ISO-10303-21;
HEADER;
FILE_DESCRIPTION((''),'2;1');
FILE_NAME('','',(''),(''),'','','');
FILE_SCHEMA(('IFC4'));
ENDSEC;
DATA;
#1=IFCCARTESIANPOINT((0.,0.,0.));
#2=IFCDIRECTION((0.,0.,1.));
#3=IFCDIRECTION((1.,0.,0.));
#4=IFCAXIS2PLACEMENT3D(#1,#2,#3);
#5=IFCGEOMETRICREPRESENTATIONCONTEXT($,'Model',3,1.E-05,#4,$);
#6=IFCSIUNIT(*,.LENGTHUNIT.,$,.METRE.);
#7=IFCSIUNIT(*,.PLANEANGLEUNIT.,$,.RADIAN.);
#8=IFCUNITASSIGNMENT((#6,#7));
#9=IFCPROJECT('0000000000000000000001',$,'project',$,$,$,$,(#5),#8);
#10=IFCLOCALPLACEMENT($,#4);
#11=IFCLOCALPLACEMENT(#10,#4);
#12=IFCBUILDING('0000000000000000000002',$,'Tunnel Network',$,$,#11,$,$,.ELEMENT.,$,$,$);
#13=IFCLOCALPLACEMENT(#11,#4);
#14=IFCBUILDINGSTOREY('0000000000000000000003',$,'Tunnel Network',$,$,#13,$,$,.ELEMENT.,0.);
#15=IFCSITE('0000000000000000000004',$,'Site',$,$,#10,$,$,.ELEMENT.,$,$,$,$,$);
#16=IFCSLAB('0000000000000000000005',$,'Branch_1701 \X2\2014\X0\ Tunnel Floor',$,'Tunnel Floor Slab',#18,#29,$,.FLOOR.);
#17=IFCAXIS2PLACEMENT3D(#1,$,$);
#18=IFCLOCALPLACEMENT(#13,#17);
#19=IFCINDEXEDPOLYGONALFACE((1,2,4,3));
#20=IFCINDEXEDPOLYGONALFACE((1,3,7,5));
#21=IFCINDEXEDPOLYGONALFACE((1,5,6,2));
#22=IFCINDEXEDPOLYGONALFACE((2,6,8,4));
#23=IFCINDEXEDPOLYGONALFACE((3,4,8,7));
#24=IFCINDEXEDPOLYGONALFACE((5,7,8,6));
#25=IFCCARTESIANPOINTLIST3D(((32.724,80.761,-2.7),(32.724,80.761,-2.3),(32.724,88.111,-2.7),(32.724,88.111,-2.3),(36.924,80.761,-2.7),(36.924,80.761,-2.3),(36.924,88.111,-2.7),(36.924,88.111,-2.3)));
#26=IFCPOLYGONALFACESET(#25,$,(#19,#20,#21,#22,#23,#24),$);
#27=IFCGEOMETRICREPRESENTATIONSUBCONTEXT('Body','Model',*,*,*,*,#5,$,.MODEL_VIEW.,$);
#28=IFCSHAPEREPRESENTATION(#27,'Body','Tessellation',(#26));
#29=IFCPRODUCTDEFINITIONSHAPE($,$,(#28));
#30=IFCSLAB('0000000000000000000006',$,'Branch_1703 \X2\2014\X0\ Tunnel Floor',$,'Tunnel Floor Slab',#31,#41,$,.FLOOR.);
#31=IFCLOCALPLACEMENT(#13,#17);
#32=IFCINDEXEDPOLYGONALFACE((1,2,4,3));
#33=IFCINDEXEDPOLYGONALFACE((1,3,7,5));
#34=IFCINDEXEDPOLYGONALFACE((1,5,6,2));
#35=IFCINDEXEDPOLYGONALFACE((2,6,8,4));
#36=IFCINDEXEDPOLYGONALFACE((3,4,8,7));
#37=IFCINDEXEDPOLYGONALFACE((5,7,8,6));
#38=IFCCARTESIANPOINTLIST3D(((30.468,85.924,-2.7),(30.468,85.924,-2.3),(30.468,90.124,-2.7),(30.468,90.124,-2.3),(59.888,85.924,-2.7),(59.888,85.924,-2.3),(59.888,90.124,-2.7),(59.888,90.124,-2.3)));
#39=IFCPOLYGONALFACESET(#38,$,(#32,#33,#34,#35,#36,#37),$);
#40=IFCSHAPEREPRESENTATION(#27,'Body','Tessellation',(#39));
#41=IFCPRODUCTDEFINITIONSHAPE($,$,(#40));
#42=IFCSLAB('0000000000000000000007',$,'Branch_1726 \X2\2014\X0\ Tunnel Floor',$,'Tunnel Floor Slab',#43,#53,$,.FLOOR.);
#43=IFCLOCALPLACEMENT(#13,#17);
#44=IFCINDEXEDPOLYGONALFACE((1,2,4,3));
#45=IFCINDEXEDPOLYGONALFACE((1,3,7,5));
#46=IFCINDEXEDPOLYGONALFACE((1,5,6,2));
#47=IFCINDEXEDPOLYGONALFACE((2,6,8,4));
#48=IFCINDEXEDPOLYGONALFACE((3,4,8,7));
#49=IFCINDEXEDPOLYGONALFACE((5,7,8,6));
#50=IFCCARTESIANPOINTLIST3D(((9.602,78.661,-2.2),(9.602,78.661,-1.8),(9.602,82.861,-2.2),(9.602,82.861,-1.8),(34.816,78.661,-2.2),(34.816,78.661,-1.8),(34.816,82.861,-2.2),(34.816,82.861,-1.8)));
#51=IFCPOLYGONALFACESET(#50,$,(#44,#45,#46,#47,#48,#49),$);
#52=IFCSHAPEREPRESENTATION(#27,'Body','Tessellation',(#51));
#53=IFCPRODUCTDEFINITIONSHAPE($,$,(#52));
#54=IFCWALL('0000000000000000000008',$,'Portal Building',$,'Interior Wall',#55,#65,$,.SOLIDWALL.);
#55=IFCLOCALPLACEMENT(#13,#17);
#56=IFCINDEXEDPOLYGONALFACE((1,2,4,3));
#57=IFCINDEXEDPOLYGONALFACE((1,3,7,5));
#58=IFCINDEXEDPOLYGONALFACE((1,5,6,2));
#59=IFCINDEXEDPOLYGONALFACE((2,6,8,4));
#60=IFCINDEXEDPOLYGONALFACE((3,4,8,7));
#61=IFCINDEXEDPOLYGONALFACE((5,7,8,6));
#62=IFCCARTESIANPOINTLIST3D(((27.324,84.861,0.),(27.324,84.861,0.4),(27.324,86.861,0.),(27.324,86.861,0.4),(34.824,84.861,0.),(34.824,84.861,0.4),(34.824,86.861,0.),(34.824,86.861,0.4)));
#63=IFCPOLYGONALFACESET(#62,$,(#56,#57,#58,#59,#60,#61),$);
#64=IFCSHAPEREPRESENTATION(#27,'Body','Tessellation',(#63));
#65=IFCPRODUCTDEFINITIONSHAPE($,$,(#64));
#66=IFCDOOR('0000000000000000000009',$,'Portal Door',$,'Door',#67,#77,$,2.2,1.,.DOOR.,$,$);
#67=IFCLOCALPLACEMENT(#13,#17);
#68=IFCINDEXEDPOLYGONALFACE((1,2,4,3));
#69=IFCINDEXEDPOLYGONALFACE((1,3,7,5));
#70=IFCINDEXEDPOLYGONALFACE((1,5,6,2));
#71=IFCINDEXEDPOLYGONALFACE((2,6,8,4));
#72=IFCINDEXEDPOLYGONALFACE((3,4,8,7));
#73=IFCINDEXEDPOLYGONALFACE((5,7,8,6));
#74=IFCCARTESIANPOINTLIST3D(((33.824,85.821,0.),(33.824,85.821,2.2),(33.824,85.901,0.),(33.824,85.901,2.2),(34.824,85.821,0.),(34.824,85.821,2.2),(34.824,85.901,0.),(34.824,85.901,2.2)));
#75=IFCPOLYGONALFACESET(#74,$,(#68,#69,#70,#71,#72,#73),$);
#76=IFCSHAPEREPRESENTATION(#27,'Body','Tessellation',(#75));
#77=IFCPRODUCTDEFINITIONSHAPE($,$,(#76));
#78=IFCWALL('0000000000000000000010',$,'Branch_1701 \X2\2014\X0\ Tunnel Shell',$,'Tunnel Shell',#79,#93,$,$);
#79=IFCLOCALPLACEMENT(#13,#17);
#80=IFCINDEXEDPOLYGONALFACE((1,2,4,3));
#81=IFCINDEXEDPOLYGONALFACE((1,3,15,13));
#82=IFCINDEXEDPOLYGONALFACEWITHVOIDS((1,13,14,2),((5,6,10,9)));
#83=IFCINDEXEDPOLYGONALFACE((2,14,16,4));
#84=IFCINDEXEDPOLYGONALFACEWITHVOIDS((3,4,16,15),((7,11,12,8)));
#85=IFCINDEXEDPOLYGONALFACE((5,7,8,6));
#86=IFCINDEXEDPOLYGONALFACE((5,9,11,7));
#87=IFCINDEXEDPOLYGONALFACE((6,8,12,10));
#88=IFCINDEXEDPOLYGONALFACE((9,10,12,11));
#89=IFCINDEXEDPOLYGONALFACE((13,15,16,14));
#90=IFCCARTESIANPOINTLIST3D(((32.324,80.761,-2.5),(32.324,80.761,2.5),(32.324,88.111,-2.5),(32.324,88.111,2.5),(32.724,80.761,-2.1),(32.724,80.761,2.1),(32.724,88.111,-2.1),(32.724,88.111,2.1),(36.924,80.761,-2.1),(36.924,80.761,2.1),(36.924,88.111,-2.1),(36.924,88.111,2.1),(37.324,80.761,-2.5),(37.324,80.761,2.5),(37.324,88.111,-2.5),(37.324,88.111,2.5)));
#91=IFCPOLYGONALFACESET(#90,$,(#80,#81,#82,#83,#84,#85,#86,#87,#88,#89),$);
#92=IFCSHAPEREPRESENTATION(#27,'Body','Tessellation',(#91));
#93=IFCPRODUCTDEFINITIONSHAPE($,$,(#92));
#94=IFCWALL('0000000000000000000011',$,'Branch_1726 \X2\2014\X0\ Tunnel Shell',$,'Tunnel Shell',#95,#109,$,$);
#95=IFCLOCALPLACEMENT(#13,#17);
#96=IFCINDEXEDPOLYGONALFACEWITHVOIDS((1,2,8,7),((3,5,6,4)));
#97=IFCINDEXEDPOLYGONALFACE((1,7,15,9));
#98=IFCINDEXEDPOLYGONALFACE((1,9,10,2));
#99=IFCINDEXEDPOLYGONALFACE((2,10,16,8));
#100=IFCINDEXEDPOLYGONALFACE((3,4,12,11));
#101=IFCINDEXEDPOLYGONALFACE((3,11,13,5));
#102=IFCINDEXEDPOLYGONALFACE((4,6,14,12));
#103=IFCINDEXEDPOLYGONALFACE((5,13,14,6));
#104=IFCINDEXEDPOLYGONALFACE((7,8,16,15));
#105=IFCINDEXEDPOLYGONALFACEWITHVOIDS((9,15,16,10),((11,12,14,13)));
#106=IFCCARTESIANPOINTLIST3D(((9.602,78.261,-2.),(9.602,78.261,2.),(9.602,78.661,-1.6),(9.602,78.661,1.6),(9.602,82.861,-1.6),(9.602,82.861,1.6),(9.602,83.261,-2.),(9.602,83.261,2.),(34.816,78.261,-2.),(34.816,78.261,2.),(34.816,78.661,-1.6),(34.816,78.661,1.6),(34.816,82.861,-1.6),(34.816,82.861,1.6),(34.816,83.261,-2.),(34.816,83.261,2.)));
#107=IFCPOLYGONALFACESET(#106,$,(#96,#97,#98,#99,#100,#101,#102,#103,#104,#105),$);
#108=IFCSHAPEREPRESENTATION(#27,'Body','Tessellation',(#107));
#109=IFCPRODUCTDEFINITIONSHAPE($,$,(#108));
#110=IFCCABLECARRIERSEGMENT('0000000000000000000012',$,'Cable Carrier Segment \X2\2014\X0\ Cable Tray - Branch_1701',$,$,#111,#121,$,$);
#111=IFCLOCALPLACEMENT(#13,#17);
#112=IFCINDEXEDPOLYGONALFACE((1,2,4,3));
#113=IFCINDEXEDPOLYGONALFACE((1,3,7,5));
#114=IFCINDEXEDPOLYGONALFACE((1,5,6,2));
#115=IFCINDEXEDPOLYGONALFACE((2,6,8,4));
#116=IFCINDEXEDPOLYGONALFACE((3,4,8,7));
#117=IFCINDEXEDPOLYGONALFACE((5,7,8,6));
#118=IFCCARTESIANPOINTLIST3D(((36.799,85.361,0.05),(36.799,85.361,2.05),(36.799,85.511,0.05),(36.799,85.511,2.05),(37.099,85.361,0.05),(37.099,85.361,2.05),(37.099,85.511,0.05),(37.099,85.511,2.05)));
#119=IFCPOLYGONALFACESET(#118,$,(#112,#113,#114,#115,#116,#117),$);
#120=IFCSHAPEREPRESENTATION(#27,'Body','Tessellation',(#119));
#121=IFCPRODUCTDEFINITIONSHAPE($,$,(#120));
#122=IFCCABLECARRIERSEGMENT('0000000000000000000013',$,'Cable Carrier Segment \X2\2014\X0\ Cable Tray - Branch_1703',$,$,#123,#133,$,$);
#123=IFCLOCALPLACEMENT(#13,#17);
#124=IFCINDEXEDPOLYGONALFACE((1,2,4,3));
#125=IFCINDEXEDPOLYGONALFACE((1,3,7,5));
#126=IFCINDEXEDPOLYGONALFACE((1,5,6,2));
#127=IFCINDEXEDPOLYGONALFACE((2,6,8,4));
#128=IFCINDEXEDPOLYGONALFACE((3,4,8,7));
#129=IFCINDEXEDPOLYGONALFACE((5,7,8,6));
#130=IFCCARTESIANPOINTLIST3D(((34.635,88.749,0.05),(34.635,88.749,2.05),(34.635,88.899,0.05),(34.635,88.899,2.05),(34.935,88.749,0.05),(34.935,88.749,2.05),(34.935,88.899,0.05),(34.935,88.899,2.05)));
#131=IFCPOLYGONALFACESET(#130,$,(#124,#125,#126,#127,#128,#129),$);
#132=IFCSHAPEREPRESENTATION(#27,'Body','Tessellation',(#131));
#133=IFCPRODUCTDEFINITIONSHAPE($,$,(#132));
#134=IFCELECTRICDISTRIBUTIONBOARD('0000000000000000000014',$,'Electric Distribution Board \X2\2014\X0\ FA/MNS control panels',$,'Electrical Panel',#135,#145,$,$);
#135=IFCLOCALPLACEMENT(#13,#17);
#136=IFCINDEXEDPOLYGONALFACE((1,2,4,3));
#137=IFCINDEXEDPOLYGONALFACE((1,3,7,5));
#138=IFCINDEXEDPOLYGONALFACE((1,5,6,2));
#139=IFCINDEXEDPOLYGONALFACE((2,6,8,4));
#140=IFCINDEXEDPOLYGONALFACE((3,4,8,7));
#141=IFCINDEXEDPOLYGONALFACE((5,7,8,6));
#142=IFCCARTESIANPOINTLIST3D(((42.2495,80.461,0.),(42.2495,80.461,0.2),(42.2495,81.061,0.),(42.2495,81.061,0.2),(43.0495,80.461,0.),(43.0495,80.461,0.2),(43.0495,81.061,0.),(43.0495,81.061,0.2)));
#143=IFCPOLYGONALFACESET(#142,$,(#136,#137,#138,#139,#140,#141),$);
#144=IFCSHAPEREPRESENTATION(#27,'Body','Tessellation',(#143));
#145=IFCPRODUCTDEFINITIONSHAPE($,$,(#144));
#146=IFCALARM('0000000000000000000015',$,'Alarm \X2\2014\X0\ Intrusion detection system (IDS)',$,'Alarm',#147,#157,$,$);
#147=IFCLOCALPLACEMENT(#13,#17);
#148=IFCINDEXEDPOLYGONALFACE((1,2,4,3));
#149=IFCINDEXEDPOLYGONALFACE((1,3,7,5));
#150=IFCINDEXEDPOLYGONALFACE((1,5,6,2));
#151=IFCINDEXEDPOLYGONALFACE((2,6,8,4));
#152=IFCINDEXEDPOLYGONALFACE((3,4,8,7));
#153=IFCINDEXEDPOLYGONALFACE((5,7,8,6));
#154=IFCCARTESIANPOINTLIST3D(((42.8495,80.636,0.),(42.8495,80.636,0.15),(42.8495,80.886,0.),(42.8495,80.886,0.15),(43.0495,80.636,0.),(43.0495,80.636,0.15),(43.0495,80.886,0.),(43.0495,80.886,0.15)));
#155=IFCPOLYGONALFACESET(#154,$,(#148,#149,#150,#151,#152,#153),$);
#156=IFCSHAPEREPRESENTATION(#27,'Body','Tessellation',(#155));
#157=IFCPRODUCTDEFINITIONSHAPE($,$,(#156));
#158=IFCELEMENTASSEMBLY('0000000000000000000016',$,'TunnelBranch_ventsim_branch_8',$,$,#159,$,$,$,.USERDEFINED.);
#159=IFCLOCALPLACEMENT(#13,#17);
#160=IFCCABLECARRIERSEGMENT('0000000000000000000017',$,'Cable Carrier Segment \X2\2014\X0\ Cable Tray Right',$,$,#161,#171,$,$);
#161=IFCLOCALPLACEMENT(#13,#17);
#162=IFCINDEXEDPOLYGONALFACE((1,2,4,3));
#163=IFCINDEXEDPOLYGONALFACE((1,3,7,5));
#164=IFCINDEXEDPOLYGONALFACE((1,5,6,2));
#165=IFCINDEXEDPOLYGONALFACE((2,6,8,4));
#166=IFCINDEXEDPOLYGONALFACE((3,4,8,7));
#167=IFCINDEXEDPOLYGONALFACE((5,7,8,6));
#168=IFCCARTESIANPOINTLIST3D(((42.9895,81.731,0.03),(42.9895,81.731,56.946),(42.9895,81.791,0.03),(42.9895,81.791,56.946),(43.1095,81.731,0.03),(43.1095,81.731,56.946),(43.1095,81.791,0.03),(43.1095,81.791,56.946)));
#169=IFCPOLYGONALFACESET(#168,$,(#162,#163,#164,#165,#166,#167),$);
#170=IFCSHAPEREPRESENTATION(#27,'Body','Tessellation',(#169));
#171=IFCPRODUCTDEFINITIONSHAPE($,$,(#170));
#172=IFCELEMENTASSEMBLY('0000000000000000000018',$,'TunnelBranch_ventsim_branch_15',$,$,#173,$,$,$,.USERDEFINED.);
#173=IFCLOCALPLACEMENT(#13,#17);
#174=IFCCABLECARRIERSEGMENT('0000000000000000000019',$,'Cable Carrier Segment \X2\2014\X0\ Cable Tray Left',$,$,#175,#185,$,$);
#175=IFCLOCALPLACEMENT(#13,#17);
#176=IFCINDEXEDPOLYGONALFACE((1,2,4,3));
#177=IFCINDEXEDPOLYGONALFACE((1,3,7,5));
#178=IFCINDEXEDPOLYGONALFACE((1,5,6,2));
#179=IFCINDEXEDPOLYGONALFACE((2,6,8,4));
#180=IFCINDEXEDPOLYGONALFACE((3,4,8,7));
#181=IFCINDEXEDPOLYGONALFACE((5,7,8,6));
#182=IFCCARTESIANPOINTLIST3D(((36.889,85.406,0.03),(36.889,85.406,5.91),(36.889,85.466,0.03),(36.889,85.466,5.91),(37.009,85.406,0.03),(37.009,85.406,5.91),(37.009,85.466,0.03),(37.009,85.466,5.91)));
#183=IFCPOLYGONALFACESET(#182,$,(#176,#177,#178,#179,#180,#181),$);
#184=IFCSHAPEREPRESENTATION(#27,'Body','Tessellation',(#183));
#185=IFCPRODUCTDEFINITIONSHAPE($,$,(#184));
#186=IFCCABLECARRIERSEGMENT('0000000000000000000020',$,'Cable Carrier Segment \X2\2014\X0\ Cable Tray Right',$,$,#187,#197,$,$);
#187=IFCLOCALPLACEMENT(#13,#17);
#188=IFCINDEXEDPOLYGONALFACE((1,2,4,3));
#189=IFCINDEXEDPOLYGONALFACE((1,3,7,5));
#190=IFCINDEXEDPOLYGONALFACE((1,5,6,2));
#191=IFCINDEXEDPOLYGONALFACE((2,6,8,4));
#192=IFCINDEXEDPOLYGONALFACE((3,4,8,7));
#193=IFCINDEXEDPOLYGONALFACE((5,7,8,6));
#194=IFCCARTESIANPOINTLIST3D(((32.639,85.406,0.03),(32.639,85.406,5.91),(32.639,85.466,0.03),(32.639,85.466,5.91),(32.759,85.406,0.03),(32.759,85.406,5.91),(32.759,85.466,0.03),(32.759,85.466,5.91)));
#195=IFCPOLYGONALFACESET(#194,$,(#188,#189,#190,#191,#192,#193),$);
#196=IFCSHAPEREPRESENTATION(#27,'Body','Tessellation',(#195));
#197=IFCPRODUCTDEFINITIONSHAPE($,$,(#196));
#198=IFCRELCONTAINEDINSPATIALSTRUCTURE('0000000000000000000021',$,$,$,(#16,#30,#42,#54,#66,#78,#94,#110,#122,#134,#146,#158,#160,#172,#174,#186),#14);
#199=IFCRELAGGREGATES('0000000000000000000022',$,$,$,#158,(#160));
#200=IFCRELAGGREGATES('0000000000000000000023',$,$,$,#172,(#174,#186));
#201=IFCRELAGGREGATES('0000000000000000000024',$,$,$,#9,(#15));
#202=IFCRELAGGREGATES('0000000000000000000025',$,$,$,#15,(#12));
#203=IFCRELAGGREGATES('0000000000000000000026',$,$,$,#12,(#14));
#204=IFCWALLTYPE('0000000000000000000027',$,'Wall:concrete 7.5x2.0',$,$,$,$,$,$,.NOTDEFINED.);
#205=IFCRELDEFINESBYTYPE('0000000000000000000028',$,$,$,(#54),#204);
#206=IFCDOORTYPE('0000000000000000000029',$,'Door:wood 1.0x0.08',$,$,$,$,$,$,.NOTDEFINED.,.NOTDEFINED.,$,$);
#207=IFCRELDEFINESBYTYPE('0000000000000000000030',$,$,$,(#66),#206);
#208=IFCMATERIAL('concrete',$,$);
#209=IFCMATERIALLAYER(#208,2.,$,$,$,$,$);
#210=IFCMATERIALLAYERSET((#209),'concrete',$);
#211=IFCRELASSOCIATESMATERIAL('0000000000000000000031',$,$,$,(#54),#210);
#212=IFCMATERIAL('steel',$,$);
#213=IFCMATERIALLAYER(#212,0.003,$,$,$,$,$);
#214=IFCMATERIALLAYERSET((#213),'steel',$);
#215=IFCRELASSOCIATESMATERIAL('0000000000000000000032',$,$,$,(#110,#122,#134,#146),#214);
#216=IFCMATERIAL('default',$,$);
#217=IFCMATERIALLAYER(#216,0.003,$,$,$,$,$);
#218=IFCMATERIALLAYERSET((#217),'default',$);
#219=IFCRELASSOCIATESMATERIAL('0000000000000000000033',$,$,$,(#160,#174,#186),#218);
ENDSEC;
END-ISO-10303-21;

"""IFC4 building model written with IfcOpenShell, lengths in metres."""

from ifc_helpers import new_model, si_unit, frame, origin_with_axes, origin_2d_with_axis, place, context, subcontext, project, spatial, rectangle, hollow_rectangle, extrude, material, layer, layer_set, layer_usage, type_object, element, aggregate, save


model = new_model("IFC4")

# Units and contexts
model_context = context("Model", 3, precision=1e-05, world=origin_with_axes())
body_context = subcontext(model_context, "Body", "Model", "MODEL_VIEW")
ifc_project = project(units=[si_unit("LENGTHUNIT", "METRE"), si_unit("PLANEANGLEUNIT", "RADIAN")], contexts=[model_context])

# Site, building, storey
site_placement = place(None, origin_with_axes())
site = spatial("IfcSite", under=ifc_project, at=site_placement, Name="Site", CompositionType="ELEMENT")
building_placement = place(site_placement, origin_with_axes())
building = spatial("IfcBuilding", under=site, at=building_placement, Name="Tunnel Network", CompositionType="ELEMENT")
storey_placement = place(building_placement, origin_with_axes())
storey = spatial("IfcBuildingStorey", under=building, at=storey_placement, Name="Tunnel Network", CompositionType="ELEMENT", Elevation=0.0)

# Slabs
placement_1 = place(storey_placement, frame((34.824, 80.761, 0.0), z_axis=(0.0, 0.0, 1.0), x_axis=(0.0, 1.0, 0.0)))
element("IfcSlab", 1, at=placement_1, inside=storey, Name="Branch_1701 — Tunnel Floor", ObjectType="Tunnel Floor Slab", PredefinedType="FLOOR", context=body_context, shape_type="SweptSolid", body=[
    extrude(rectangle(XDim=0.4, YDim=4.2, at=origin_2d_with_axis()), frame((0.0, 0.0, -2.5), z_axis=(1.0, 0.0, 0.0), x_axis=(0.0, 0.0, 1.0)), (0.0, 0.0, 1.0), 7.35),
])
slab_1_placement = place(storey_placement, frame((30.468, 88.024, 0.0), z_axis=(0.0, 0.0, 1.0), x_axis=(1.0, 0.0, 0.0)))
element("IfcSlab", 2, at=slab_1_placement, inside=storey, Name="Branch_1703 — Tunnel Floor", ObjectType="Tunnel Floor Slab", PredefinedType="FLOOR", context=body_context, shape_type="SweptSolid", body=[
    extrude(rectangle(XDim=0.4, YDim=4.2, at=origin_2d_with_axis()), frame((0.0, 0.0, -2.5), z_axis=(1.0, 0.0, 0.0), x_axis=(0.0, 0.0, 1.0)), (0.0, 0.0, 1.0), 29.42),
])
placement_2 = place(storey_placement, frame((34.816, 80.761, 0.0), z_axis=(0.0, 0.0, 1.0), x_axis=(-1.0, 0.0, 0.0)))
element("IfcSlab", 3, at=placement_2, inside=storey, Name="Branch_1726 — Tunnel Floor", ObjectType="Tunnel Floor Slab", PredefinedType="FLOOR", context=body_context, shape_type="SweptSolid", body=[
    extrude(rectangle(XDim=0.4, YDim=4.2, at=origin_2d_with_axis()), frame((0.0, 0.0, -2.0), z_axis=(1.0, 0.0, 0.0), x_axis=(0.0, 0.0, 1.0)), (0.0, 0.0, 1.0), 25.214),
])

# Wall
ifc_material_1 = material(Name="concrete")
ifc_layer_1 = layer(ifc_material_1, 2.0)
ifc_layer_set_1 = layer_set([ifc_layer_1], Name="concrete")
ifc_layer_usage_1 = layer_usage(ifc_layer_set_1, "AXIS2", "POSITIVE", 0.0)
wall_type = type_object("IfcWallType", Name="Wall:concrete 7.5x2.0")
wall_1_placement = place(storey_placement, frame((31.074, 85.861, 0.0), z_axis=(0.0, 0.0, 1.0), x_axis=(1.0, 0.0, 0.0)))
element("IfcWall", 4, at=wall_1_placement, inside=storey, type_object=wall_type, material=ifc_layer_usage_1, Name="Portal Building", ObjectType="Interior Wall", PredefinedType="SOLIDWALL", context=body_context, shape_type="SweptSolid", body=[
    extrude(rectangle(XDim=7.5, YDim=2.0, at=origin_2d_with_axis()), origin_with_axes(), (0.0, 0.0, 1.0), 0.4),
])

# Door
door_type = type_object("IfcDoorType", Name="Door:wood 1.0x0.08")
door_placement = place(storey_placement, frame((34.324, 85.861, 0.0), z_axis=(0.0, 0.0, 1.0), x_axis=(1.0, 0.0, 0.0)))
element("IfcDoor", 5, at=door_placement, inside=storey, type_object=door_type, Name="Portal Door", ObjectType="Door", OverallHeight=2.2, OverallWidth=1.0, PredefinedType="DOOR", context=body_context, shape_type="SweptSolid", body=[
    extrude(rectangle(XDim=1.0, YDim=0.08, at=origin_2d_with_axis()), origin_with_axes(), (0.0, 0.0, 1.0), 2.2),
])

# Walls
element("IfcWall", 6, at=placement_1, inside=storey, Name="Branch_1701 — Tunnel Shell", ObjectType="Tunnel Shell", context=body_context, shape_type="SweptSolid", body=[
    extrude(hollow_rectangle(XDim=5.0, YDim=5.0, WallThickness=0.4, at=origin_2d_with_axis()), frame((0.0, 0.0, 0.0), z_axis=(1.0, 0.0, 0.0), x_axis=(0.0, 0.0, 1.0)), (0.0, 0.0, 1.0), 7.35),
])
element("IfcWall", 7, at=placement_2, inside=storey, Name="Branch_1726 — Tunnel Shell", ObjectType="Tunnel Shell", context=body_context, shape_type="SweptSolid", body=[
    extrude(hollow_rectangle(XDim=4.0, YDim=5.0, WallThickness=0.4, at=origin_2d_with_axis()), frame((0.0, 0.0, 0.0), z_axis=(1.0, 0.0, 0.0), x_axis=(0.0, 0.0, 1.0)), (0.0, 0.0, 1.0), 25.214),
])

# Cable carrier segments
ifc_material_2 = material(Name="steel")
ifc_layer_2 = layer(ifc_material_2, 0.003)
ifc_layer_set_2 = layer_set([ifc_layer_2], Name="steel")
ifc_layer_usage_2 = layer_usage(ifc_layer_set_2, "AXIS2", "POSITIVE", 0.0)
cable_carrier_segment_1_placement = place(storey_placement, frame((36.949, 85.436, 0.05), z_axis=(0.0, 0.0, 1.0), x_axis=(-1.0, 0.0, 0.0)))
element("IfcCableCarrierSegment", 8, at=cable_carrier_segment_1_placement, inside=storey, material=ifc_layer_usage_2, Name="Cable Carrier Segment — Cable Tray - Branch_1701", context=body_context, shape_type="SweptSolid", body=[
    extrude(rectangle(XDim=0.3, YDim=0.15, at=origin_2d_with_axis()), origin_with_axes(), (0.0, 0.0, 1.0), 2.0),
])
ifc_layer_usage_3 = layer_usage(ifc_layer_set_2, "AXIS2", "POSITIVE", 0.0)
cable_carrier_segment_2_placement = place(storey_placement, frame((34.785, 88.824, 0.05), z_axis=(0.0, 0.0, 1.0), x_axis=(-1.0, 0.0, 0.0)))
element("IfcCableCarrierSegment", 9, at=cable_carrier_segment_2_placement, inside=storey, material=ifc_layer_usage_3, Name="Cable Carrier Segment — Cable Tray - Branch_1703", context=body_context, shape_type="SweptSolid", body=[
    extrude(rectangle(XDim=0.3, YDim=0.15, at=origin_2d_with_axis()), origin_with_axes(), (0.0, 0.0, 1.0), 2.0),
])

# Electric distribution board
ifc_layer_usage_4 = layer_usage(ifc_layer_set_2, "AXIS2", "POSITIVE", 0.0)
electric_distribution_board_placement = place(storey_placement, frame((43.0495, 80.761, 0.1), z_axis=(-1.0, 0.0, 0.0), x_axis=(0.0, 1.0, 0.0)))
element("IfcElectricDistributionBoard", 10, at=electric_distribution_board_placement, inside=storey, material=ifc_layer_usage_4, Name="Electric Distribution Board — FA/MNS control panels", ObjectType="Electrical Panel", context=body_context, shape_type="SweptSolid", body=[
    extrude(rectangle(XDim=0.6, YDim=0.2, at=origin_2d_with_axis()), origin_with_axes(), (0.0, 0.0, 1.0), 0.8),
])

# Alarm
ifc_layer_usage_5 = layer_usage(ifc_layer_set_2, "AXIS2", "POSITIVE", 0.0)
alarm_1_placement = place(storey_placement, frame((43.0495, 80.761, 0.075), z_axis=(-1.0, 0.0, 0.0), x_axis=(0.0, 1.0, 0.0)))
element("IfcAlarm", 11, at=alarm_1_placement, inside=storey, material=ifc_layer_usage_5, Name="Alarm — Intrusion detection system (IDS)", ObjectType="Alarm", context=body_context, shape_type="SweptSolid", body=[
    extrude(rectangle(XDim=0.25, YDim=0.15, at=origin_2d_with_axis()), origin_with_axes(), (0.0, 0.0, 1.0), 0.2),
])

# Element assembly, cable carrier segment
assembly_1_placement = place(storey_placement, frame((47.6745, 80.761, 43.5572), z_axis=(0.0, 1.0, 0.0), x_axis=(-1.0, 0.0, 0.0)))
assembly_1 = element("IfcElementAssembly", 12, at=assembly_1_placement, inside=storey, Name="TunnelBranch_ventsim_branch_8", PredefinedType="USERDEFINED")
ifc_material_3 = material(Name="default")
ifc_layer_3 = layer(ifc_material_3, 0.003)
ifc_layer_set_3 = layer_set([ifc_layer_3], Name="default")
ifc_layer_usage_6 = layer_usage(ifc_layer_set_3, "AXIS2", "POSITIVE", 0.0)
cable_carrier_segment_3_placement = place(storey_placement, frame((43.0495, 81.761, 0.03), z_axis=(0.0, 0.0, 1.0), x_axis=(-1.0, 0.0, 0.0)))
cable_carrier_segment_3 = element("IfcCableCarrierSegment", 13, at=cable_carrier_segment_3_placement, inside=storey, material=ifc_layer_usage_6, Name="Cable Carrier Segment — Cable Tray Right", context=body_context, shape_type="SweptSolid", body=[
    extrude(rectangle(XDim=0.12, YDim=0.06, at=origin_2d_with_axis()), origin_with_axes(), (0.0, 0.0, 1.0), 56.916),
])
aggregate(assembly_1, [cable_carrier_segment_3])

# Element assembly, cable carrier segments
assembly_2_placement = place(storey_placement, frame((32.324, 84.436, 2.0), z_axis=(0.0, 1.0, 0.0), x_axis=(-1.0, 0.0, 0.0)))
assembly_2 = element("IfcElementAssembly", 14, at=assembly_2_placement, inside=storey, Name="TunnelBranch_ventsim_branch_15", PredefinedType="USERDEFINED")
ifc_layer_usage_7 = layer_usage(ifc_layer_set_3, "AXIS2", "POSITIVE", 0.0)
cable_carrier_segment_4_placement = place(storey_placement, frame((36.949, 85.436, 0.03), z_axis=(0.0, 0.0, 1.0), x_axis=(-1.0, 0.0, 0.0)))
cable_carrier_segment_4 = element("IfcCableCarrierSegment", 15, at=cable_carrier_segment_4_placement, inside=storey, material=ifc_layer_usage_7, Name="Cable Carrier Segment — Cable Tray Left", context=body_context, shape_type="SweptSolid", body=[
    extrude(rectangle(XDim=0.12, YDim=0.06, at=origin_2d_with_axis()), origin_with_axes(), (0.0, 0.0, 1.0), 5.88),
])
ifc_layer_usage_8 = layer_usage(ifc_layer_set_3, "AXIS2", "POSITIVE", 0.0)
cable_carrier_segment_5_placement = place(storey_placement, frame((32.699, 85.436, 0.03), z_axis=(0.0, 0.0, 1.0), x_axis=(-1.0, 0.0, 0.0)))
cable_carrier_segment_5 = element("IfcCableCarrierSegment", 16, at=cable_carrier_segment_5_placement, inside=storey, material=ifc_layer_usage_8, Name="Cable Carrier Segment — Cable Tray Right", context=body_context, shape_type="SweptSolid", body=[
    extrude(rectangle(XDim=0.12, YDim=0.06, at=origin_2d_with_axis()), origin_with_axes(), (0.0, 0.0, 1.0), 5.88),
])
aggregate(assembly_2, [cable_carrier_segment_4, cable_carrier_segment_5])

save(model, "model.ifc")
